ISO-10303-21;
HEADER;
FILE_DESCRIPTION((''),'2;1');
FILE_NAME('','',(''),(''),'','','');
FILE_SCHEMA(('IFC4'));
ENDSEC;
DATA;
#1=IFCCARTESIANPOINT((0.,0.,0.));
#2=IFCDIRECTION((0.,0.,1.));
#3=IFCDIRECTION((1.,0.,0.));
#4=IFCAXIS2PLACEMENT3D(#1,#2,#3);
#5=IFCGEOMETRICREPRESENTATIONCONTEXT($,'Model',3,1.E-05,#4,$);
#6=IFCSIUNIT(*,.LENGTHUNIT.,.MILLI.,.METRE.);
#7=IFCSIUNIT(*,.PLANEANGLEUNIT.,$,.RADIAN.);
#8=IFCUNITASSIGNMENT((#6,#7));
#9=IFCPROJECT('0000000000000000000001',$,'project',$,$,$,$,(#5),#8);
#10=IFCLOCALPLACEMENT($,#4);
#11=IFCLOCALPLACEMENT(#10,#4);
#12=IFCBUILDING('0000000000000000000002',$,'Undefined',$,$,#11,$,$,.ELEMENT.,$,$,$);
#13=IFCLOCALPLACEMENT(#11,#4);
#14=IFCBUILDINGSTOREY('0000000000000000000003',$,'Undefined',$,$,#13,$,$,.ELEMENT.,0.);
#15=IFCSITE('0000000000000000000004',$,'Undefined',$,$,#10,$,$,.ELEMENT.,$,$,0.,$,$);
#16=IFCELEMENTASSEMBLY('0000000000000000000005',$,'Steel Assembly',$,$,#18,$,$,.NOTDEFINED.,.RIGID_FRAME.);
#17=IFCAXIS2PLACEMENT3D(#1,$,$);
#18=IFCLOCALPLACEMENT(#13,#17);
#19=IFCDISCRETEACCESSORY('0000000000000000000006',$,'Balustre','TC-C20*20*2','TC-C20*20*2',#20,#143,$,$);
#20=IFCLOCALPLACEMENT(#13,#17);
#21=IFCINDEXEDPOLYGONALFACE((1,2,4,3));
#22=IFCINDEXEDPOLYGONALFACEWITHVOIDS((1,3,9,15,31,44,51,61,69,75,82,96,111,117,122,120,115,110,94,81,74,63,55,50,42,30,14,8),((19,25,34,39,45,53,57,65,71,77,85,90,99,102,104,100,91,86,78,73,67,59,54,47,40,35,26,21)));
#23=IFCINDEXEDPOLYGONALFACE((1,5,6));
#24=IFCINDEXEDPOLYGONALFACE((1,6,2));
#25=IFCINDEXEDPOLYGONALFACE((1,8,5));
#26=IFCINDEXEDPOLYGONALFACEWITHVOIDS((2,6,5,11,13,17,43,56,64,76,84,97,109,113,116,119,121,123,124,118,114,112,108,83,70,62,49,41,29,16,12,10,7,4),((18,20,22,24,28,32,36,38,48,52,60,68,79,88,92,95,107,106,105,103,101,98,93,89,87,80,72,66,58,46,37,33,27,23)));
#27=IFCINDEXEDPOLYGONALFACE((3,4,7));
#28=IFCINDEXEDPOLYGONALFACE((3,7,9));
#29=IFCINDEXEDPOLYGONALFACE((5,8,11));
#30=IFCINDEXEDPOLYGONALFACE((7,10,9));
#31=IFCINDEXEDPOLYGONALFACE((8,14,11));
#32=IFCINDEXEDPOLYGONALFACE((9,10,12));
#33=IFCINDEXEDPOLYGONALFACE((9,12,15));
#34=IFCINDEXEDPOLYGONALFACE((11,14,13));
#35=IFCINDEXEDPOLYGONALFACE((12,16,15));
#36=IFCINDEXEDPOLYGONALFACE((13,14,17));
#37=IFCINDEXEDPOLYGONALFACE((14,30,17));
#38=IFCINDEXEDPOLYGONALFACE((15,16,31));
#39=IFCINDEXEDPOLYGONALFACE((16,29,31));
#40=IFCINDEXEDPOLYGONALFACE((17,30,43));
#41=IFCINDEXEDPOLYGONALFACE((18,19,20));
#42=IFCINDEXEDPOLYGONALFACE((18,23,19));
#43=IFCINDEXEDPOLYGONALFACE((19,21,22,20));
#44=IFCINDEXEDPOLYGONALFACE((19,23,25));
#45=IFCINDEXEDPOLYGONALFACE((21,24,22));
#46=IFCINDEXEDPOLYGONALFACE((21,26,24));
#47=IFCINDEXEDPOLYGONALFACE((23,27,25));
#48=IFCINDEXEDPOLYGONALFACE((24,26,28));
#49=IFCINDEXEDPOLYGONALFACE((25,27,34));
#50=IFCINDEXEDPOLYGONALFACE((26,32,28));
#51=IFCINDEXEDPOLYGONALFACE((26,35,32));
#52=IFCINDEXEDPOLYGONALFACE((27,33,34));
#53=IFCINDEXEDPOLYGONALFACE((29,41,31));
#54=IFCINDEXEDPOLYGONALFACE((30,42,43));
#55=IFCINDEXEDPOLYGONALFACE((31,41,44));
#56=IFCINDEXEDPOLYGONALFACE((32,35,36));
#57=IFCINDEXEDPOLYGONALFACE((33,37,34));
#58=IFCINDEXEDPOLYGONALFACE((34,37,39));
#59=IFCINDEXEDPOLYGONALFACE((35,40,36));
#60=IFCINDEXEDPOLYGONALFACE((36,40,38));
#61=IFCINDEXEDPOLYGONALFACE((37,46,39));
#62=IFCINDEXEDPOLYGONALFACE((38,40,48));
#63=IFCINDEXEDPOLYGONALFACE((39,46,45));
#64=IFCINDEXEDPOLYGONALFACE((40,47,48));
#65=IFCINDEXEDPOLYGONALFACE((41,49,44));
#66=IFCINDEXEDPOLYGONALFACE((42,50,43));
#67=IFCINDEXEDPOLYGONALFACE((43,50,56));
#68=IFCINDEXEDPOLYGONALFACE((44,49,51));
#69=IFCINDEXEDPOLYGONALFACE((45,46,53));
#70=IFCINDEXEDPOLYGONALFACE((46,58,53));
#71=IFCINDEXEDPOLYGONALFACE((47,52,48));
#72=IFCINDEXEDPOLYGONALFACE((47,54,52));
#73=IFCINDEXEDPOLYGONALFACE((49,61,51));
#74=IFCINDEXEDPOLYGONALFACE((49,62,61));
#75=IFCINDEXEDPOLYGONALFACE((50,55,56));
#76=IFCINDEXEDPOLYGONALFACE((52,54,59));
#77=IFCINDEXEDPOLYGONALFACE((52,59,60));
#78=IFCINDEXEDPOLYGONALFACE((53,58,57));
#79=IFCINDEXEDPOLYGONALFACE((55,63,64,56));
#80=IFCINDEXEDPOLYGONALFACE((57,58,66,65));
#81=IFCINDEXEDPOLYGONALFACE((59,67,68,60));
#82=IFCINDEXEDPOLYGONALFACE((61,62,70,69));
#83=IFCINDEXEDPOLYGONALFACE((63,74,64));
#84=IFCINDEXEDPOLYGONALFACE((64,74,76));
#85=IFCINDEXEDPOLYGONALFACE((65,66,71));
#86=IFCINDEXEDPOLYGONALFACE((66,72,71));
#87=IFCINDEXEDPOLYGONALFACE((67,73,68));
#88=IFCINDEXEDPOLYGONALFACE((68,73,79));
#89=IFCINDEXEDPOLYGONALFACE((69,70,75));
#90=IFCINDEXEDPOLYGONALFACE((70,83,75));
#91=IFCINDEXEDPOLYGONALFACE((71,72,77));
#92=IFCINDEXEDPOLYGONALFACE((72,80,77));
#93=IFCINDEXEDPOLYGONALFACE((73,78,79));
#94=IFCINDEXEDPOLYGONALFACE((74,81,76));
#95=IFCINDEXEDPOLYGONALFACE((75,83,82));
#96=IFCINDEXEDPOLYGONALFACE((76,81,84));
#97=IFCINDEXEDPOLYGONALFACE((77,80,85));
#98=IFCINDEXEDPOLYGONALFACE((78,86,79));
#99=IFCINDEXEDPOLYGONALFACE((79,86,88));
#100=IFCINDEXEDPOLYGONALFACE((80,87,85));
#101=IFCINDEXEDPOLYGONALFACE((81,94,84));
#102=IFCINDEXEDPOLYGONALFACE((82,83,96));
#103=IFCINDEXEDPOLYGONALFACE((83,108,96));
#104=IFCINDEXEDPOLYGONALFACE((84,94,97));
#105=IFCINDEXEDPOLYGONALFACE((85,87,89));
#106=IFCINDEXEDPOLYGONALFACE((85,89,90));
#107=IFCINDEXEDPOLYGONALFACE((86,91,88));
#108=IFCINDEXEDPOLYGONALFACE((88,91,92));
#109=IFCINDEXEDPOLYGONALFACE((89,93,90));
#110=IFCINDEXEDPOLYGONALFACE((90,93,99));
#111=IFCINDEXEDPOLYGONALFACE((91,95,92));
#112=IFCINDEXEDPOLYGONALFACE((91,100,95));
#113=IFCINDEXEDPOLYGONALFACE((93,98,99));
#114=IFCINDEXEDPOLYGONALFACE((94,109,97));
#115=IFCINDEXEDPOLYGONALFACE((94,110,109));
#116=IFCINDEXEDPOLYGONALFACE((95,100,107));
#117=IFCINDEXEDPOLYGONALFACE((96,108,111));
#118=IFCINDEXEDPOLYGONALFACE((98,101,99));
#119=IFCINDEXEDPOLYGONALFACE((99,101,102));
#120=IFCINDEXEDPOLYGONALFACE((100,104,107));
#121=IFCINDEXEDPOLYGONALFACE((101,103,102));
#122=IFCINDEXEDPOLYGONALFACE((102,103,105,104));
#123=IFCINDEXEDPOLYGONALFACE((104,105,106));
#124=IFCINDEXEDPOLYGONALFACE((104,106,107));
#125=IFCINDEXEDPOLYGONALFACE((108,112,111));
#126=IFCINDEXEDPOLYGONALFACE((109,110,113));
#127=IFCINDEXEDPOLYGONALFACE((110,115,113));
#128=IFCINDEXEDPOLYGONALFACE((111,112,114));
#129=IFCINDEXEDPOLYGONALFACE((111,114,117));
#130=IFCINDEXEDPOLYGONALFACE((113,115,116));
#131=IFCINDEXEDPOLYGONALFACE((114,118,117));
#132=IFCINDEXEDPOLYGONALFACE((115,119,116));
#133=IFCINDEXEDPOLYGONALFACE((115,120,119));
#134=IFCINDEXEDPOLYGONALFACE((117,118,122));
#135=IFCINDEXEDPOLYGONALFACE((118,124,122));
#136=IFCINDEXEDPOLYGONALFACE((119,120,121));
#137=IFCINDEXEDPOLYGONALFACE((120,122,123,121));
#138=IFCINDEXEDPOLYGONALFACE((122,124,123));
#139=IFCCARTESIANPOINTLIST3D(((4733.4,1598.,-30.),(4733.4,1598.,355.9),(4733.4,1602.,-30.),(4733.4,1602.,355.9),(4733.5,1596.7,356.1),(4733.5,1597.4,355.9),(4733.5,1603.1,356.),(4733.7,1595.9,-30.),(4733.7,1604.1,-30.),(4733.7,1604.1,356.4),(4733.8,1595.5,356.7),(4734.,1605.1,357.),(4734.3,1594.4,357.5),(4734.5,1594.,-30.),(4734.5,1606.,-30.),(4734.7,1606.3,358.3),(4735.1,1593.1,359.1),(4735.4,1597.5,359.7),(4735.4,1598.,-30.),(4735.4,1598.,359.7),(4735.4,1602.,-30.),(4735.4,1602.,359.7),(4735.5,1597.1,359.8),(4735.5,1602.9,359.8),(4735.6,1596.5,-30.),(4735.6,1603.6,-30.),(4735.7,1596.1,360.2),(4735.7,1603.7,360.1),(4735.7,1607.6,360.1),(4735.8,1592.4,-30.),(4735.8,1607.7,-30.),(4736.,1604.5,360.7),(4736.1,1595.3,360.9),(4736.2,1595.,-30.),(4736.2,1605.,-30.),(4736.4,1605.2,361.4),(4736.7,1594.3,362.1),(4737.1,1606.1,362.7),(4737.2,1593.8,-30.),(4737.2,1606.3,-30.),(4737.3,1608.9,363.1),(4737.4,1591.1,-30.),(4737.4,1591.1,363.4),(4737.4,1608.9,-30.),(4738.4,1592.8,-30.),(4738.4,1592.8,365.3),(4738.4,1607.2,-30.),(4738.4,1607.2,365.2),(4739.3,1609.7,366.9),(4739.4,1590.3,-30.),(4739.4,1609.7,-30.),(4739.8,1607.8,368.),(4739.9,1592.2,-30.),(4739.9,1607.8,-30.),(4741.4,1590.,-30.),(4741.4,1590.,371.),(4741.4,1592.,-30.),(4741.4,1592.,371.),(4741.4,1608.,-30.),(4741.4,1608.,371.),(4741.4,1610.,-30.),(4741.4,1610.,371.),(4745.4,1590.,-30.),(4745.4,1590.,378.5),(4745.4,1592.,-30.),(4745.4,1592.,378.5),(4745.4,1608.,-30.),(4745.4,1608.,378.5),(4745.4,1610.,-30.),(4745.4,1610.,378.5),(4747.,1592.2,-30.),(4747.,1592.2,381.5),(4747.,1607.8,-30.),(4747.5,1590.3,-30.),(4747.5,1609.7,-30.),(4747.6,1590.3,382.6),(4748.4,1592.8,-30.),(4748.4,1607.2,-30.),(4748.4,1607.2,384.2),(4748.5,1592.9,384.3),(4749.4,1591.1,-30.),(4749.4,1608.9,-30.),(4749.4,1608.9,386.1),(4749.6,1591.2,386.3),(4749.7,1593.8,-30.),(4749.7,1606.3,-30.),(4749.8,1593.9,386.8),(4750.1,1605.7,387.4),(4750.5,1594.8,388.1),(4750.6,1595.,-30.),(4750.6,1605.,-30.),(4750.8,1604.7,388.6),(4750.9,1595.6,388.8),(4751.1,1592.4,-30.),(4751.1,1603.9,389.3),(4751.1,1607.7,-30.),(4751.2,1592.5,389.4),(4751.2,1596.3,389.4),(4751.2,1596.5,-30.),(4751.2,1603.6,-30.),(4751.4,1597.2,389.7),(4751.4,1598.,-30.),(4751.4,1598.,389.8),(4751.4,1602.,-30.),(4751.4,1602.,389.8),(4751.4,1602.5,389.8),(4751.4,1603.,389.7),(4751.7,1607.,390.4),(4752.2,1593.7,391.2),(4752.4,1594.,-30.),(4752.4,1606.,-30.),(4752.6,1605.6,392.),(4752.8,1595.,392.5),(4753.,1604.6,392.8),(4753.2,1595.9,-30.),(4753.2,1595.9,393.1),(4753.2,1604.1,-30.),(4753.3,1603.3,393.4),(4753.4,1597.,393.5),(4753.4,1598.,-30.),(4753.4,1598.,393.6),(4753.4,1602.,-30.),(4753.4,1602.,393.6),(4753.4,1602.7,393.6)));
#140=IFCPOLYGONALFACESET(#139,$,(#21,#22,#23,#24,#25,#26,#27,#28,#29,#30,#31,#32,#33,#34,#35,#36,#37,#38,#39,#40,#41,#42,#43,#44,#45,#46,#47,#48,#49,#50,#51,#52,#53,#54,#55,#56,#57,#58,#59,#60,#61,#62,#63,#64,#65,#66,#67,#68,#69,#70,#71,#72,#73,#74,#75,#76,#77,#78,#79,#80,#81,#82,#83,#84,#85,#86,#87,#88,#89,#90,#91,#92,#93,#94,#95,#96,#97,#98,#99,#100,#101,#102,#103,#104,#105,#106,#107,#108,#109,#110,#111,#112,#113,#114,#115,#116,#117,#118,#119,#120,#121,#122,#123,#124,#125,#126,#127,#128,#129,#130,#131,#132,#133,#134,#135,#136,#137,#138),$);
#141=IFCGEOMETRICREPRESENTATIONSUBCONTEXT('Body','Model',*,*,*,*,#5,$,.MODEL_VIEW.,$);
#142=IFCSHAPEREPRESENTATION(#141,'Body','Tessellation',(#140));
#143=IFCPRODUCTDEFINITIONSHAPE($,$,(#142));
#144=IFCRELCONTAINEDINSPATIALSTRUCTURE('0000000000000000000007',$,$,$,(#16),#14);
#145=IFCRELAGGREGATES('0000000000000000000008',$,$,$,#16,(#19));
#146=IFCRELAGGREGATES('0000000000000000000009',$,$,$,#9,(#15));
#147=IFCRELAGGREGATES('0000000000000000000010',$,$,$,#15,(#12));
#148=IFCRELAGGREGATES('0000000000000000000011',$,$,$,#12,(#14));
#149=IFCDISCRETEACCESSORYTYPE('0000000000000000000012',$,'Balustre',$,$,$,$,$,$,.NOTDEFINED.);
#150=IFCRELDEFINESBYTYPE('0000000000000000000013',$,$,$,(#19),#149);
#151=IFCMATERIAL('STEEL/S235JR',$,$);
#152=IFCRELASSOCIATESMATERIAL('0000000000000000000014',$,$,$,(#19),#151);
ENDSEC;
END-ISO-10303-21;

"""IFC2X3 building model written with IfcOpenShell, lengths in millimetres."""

from ifc_helpers import new_model, si_unit, frame, origin_with_axes, origin_2d_with_axis, place, context, subcontext, project, spatial, hollow_rectangle, extrude, clip, halfspace, material, type_object, element, aggregate, save


model = new_model("IFC2X3")

# Units and contexts
model_context = context("Model", 3, precision=1e-05, world=origin_with_axes())
body_context = subcontext(model_context, "Body", "Model", "MODEL_VIEW")
ifc_project = project(units=[si_unit("LENGTHUNIT", "METRE", prefix="MILLI"), si_unit("PLANEANGLEUNIT", "RADIAN")], contexts=[model_context])

# Site, building, storey
site_placement = place(None, origin_with_axes())
site = spatial("IfcSite", under=ifc_project, at=site_placement, Name="Undefined", CompositionType="ELEMENT", RefElevation=0.0)
building_placement = place(site_placement, origin_with_axes())
building = spatial("IfcBuilding", under=site, at=building_placement, Name="Undefined", CompositionType="ELEMENT")
storey_placement = place(building_placement, origin_with_axes())
storey = spatial("IfcBuildingStorey", under=building, at=storey_placement, Name="Undefined", CompositionType="ELEMENT", Elevation=0.0)

# Shared definitions
ifc_material = material(Name="STEEL/S235JR")

# Element assembly, discrete accessory
assembly_1_placement = place(storey_placement, origin_with_axes())
assembly_1 = element("IfcElementAssembly", 1, at=assembly_1_placement, inside=storey, Name="Steel Assembly", AssemblyPlace="NOTDEFINED", PredefinedType="RIGID_FRAME")
discrete_accessory_type_1 = type_object("IfcDiscreteAccessoryType", Name="Balustre")
discrete_accessory_1_placement = place(assembly_1_placement, frame((4743.4, 1600.0, -30.0), z_axis=(0.0, 0.0, 1.0), x_axis=(1.0, 0.0, 0.0)))
discrete_accessory_1 = element("IfcDiscreteAccessory", 2, at=discrete_accessory_1_placement, type_object=discrete_accessory_type_1, material=ifc_material, Name="Balustre", Description="TC-C20*20*2", ObjectType="TC-C20*20*2", context=body_context, shape_type="Clipping", body=[
    clip(extrude(hollow_rectangle(XDim=20.0, YDim=20.0, WallThickness=2.0, InnerFilletRadius=6.0, OuterFilletRadius=8.0, at=origin_2d_with_axis()), frame((0.0, 0.0, 423.8), z_axis=(0.0, 0.0, -1.0), x_axis=(-1.0, 0.0, 0.0)), (0.0, 0.0, 1.0), 423.8), halfspace(frame((13.3, 0.0, 429.9), z_axis=(0.883506, 0.000005, -0.46842), x_axis=(-0.000005, 1.0, 0.0)), True)),
])

aggregate(assembly_1, [discrete_accessory_1])

save(model, "model.ifc")
